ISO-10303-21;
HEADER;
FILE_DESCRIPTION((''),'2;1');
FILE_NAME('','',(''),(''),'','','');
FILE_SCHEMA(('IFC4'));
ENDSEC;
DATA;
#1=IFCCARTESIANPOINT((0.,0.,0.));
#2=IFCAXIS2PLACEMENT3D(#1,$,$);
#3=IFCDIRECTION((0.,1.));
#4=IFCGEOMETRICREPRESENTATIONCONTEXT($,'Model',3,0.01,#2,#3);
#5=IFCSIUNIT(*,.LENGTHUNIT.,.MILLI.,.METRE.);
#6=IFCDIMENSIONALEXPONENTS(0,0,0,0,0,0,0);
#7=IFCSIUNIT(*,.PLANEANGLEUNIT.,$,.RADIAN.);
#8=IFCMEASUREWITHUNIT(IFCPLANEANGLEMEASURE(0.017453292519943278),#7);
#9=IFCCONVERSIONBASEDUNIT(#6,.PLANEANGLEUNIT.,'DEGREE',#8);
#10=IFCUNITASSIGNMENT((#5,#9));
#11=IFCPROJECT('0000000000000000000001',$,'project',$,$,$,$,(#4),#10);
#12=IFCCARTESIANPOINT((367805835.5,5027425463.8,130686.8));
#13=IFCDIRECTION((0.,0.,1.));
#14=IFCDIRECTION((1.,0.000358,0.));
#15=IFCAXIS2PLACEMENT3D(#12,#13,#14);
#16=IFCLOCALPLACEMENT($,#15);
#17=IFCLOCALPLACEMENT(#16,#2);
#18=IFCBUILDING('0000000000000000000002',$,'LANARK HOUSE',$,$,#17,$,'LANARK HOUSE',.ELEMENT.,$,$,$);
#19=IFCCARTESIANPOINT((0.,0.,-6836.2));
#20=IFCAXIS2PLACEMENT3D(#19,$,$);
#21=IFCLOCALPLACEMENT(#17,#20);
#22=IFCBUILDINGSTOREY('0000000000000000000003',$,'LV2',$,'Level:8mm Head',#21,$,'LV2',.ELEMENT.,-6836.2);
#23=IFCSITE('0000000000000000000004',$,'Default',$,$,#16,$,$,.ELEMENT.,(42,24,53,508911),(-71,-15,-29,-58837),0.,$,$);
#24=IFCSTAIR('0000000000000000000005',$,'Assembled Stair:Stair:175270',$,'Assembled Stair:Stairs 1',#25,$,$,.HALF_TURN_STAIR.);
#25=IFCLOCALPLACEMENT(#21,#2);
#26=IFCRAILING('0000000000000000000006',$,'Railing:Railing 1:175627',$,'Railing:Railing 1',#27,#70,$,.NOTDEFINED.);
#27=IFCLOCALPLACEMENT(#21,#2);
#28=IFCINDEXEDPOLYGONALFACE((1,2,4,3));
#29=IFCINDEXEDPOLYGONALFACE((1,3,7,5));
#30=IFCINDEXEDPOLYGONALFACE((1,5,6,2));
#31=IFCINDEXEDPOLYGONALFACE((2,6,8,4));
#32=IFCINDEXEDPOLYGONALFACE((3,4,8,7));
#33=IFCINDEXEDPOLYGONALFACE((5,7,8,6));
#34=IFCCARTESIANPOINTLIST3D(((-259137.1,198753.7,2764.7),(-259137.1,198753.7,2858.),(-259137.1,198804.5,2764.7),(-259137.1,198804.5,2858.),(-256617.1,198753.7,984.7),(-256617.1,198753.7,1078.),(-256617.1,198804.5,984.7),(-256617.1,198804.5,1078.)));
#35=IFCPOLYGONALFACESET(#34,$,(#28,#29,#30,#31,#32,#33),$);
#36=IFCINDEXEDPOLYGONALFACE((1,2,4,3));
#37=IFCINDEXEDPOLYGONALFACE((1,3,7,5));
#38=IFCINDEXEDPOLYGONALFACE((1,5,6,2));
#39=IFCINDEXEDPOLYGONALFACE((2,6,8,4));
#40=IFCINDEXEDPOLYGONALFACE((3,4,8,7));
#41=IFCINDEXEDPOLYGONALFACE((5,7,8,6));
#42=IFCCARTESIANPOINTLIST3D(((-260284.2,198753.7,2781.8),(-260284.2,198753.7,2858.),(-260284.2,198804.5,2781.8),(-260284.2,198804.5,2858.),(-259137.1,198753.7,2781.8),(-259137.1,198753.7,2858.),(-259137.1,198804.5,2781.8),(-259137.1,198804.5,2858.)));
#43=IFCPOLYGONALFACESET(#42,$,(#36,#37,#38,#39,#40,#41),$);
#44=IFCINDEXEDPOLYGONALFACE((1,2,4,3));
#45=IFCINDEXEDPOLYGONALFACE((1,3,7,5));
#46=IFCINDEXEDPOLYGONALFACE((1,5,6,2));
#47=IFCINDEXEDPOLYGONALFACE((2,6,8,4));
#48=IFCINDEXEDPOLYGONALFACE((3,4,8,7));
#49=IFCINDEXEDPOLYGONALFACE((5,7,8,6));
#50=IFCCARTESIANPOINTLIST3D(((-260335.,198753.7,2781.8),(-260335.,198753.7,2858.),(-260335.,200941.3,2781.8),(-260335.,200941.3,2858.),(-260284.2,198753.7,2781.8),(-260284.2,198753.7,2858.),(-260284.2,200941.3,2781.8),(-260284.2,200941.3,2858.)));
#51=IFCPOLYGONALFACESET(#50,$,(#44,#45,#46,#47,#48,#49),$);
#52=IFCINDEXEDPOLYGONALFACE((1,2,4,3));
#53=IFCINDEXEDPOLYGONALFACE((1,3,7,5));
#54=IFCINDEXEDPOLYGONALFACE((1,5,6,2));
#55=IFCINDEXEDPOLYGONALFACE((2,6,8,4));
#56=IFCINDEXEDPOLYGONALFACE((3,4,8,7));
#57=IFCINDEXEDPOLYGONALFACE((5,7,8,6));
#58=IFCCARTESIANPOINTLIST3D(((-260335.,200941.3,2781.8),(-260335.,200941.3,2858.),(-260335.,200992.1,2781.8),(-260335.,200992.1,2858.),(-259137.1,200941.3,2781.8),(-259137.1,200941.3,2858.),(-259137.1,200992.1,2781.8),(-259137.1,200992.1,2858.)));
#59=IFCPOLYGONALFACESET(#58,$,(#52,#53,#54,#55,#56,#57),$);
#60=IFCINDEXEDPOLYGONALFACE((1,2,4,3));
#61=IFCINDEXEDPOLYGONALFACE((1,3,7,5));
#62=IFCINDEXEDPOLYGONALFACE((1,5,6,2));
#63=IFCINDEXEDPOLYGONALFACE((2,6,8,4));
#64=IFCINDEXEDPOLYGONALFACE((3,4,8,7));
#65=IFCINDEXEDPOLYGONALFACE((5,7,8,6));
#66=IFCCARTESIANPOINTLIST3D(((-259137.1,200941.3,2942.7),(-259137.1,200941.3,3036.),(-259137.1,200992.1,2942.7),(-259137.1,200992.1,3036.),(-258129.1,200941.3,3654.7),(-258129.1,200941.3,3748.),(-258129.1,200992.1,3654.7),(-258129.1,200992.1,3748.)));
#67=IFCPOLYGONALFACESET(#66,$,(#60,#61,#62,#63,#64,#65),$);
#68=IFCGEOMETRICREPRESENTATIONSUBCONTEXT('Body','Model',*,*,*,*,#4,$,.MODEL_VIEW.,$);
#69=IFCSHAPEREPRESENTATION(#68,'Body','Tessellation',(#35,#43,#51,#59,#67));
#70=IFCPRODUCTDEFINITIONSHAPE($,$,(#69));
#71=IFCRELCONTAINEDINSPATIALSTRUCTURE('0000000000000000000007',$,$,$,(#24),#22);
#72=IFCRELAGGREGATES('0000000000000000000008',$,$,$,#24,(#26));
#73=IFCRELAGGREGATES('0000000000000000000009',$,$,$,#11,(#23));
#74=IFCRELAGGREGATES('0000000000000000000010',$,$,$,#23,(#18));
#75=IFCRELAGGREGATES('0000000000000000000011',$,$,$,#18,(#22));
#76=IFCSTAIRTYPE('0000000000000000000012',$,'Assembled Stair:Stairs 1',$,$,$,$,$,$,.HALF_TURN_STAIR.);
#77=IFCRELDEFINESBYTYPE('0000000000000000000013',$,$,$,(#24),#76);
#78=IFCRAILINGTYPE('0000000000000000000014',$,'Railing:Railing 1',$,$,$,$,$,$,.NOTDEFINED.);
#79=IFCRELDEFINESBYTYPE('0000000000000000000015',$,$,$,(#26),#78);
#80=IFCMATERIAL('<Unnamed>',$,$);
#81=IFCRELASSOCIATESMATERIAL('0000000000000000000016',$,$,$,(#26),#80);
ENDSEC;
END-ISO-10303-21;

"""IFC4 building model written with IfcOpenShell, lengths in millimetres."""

from ifc_helpers import new_model, entity, si_unit, converted_unit, direction, frame, origin, place, context, subcontext, project, spatial, indexed_curve, outline, extrude, material, type_object, element, aggregate, save


model = new_model("IFC4")

# Units and contexts
model_context = context("Model", 3, precision=0.01, world=origin(), true_north=direction((0.0, 1.0)))
body_context = subcontext(model_context, "Body", "Model", "MODEL_VIEW")
ifc_project = project(units=[si_unit("LENGTHUNIT", "METRE", prefix="MILLI"), converted_unit("PLANEANGLEUNIT", "DEGREE", entity("IfcPlaneAngleMeasure", 0.017453292519943278), si_unit("PLANEANGLEUNIT", "RADIAN"), dimensions=[0, 0, 0, 0, 0, 0, 0])], contexts=[model_context])

# Site, building, storey
site_placement = place(None, frame((367805835.5, 5027425463.8, 130686.8), z_axis=(0.0, 0.0, 1.0), x_axis=(1.0, 0.000358, 0.0)))
site = spatial("IfcSite", under=ifc_project, at=site_placement, Name="Default", CompositionType="ELEMENT", RefLatitude=(42, 24, 53, 508911), RefLongitude=(-71, -15, -29, -58837), RefElevation=0.0)
building_placement = place(site_placement, origin())
building = spatial("IfcBuilding", under=site, at=building_placement, Name="LANARK HOUSE", LongName="LANARK HOUSE", CompositionType="ELEMENT")
storey_placement = place(building_placement, frame((0.0, 0.0, -6836.2)))
storey = spatial("IfcBuildingStorey", under=building, at=storey_placement, Name="LV2", ObjectType="Level:8mm Head", LongName="LV2", CompositionType="ELEMENT", Elevation=-6836.2)

# Stair
stair_type = type_object("IfcStairType", Name="Assembled Stair:Stairs 1", PredefinedType="HALF_TURN_STAIR")
stair_placement = place(storey_placement, origin())
stair = element("IfcStair", 1, at=stair_placement, inside=storey, type_object=stair_type, Name="Assembled Stair:Stair:175270", ObjectType="Assembled Stair:Stairs 1", PredefinedType="HALF_TURN_STAIR")
ifc_material_1 = material(Name="<Unnamed>")

# Railing
railing_type = type_object("IfcRailingType", Name="Railing:Railing 1", PredefinedType="NOTDEFINED")
railing_placement = place(stair_placement, frame((-260335.0, 198753.7, 984.7)))
railing = element("IfcRailing", 2, at=railing_placement, type_object=railing_type, material=ifc_material_1, Name="Railing:Railing 1:175627", ObjectType="Railing:Railing 1", PredefinedType="NOTDEFINED", context=body_context, shape_type="SweptSolid", body=[
    extrude(outline(indexed_curve([(-1569.5, -38.1), (1515.7, -38.1), (1569.5, 38.1), (-1515.7, 38.1), (-1569.5, -38.1)], self_intersect=False)), frame((2457.9, 0.0, 936.6), z_axis=(0.0, 1.0, 0.0), x_axis=(-0.816788, 0.0, 0.576938)), (0.0, 0.0, 1.0), 50.8),
    extrude(outline(indexed_curve([(-573.6, -25.4), (573.6, -25.4), (573.6, 25.4), (-573.6, 25.4), (-573.6, -25.4)], self_intersect=False)), frame((624.4, 25.4, 1797.1), z_axis=(0.0, 0.0, 1.0), x_axis=(-1.0, 0.0, 0.0)), (0.0, 0.0, 1.0), 76.2),
    extrude(outline(indexed_curve([(-1093.8, -25.4), (1093.8, -25.4), (1093.8, 25.4), (-1093.8, 25.4), (-1093.8, -25.4)], self_intersect=False)), frame((25.4, 1093.8, 1797.1), z_axis=(0.0, 0.0, 1.0), x_axis=(0.0, 1.0, 0.0)), (0.0, 0.0, 1.0), 76.2),
    extrude(outline(indexed_curve([(-599.0, -25.4), (599.0, -25.4), (599.0, 25.4), (-599.0, 25.4), (-599.0, -25.4)], self_intersect=False)), frame((599.0, 2213.0, 1797.1)), (0.0, 0.0, 1.0), 76.2),
    extrude(outline(indexed_curve([(-590.1, -38.1), (644.0, -38.1), (590.1, 38.1), (-644.0, 38.1), (-590.1, -38.1)], self_intersect=False)), frame((1701.9, 2187.6, 2360.6), z_axis=(0.0, 1.0, 0.0), x_axis=(0.816788, 0.0, 0.576938)), (0.0, 0.0, 1.0), 50.8),
])
aggregate(stair, [railing])

save(model, "model.ifc")
